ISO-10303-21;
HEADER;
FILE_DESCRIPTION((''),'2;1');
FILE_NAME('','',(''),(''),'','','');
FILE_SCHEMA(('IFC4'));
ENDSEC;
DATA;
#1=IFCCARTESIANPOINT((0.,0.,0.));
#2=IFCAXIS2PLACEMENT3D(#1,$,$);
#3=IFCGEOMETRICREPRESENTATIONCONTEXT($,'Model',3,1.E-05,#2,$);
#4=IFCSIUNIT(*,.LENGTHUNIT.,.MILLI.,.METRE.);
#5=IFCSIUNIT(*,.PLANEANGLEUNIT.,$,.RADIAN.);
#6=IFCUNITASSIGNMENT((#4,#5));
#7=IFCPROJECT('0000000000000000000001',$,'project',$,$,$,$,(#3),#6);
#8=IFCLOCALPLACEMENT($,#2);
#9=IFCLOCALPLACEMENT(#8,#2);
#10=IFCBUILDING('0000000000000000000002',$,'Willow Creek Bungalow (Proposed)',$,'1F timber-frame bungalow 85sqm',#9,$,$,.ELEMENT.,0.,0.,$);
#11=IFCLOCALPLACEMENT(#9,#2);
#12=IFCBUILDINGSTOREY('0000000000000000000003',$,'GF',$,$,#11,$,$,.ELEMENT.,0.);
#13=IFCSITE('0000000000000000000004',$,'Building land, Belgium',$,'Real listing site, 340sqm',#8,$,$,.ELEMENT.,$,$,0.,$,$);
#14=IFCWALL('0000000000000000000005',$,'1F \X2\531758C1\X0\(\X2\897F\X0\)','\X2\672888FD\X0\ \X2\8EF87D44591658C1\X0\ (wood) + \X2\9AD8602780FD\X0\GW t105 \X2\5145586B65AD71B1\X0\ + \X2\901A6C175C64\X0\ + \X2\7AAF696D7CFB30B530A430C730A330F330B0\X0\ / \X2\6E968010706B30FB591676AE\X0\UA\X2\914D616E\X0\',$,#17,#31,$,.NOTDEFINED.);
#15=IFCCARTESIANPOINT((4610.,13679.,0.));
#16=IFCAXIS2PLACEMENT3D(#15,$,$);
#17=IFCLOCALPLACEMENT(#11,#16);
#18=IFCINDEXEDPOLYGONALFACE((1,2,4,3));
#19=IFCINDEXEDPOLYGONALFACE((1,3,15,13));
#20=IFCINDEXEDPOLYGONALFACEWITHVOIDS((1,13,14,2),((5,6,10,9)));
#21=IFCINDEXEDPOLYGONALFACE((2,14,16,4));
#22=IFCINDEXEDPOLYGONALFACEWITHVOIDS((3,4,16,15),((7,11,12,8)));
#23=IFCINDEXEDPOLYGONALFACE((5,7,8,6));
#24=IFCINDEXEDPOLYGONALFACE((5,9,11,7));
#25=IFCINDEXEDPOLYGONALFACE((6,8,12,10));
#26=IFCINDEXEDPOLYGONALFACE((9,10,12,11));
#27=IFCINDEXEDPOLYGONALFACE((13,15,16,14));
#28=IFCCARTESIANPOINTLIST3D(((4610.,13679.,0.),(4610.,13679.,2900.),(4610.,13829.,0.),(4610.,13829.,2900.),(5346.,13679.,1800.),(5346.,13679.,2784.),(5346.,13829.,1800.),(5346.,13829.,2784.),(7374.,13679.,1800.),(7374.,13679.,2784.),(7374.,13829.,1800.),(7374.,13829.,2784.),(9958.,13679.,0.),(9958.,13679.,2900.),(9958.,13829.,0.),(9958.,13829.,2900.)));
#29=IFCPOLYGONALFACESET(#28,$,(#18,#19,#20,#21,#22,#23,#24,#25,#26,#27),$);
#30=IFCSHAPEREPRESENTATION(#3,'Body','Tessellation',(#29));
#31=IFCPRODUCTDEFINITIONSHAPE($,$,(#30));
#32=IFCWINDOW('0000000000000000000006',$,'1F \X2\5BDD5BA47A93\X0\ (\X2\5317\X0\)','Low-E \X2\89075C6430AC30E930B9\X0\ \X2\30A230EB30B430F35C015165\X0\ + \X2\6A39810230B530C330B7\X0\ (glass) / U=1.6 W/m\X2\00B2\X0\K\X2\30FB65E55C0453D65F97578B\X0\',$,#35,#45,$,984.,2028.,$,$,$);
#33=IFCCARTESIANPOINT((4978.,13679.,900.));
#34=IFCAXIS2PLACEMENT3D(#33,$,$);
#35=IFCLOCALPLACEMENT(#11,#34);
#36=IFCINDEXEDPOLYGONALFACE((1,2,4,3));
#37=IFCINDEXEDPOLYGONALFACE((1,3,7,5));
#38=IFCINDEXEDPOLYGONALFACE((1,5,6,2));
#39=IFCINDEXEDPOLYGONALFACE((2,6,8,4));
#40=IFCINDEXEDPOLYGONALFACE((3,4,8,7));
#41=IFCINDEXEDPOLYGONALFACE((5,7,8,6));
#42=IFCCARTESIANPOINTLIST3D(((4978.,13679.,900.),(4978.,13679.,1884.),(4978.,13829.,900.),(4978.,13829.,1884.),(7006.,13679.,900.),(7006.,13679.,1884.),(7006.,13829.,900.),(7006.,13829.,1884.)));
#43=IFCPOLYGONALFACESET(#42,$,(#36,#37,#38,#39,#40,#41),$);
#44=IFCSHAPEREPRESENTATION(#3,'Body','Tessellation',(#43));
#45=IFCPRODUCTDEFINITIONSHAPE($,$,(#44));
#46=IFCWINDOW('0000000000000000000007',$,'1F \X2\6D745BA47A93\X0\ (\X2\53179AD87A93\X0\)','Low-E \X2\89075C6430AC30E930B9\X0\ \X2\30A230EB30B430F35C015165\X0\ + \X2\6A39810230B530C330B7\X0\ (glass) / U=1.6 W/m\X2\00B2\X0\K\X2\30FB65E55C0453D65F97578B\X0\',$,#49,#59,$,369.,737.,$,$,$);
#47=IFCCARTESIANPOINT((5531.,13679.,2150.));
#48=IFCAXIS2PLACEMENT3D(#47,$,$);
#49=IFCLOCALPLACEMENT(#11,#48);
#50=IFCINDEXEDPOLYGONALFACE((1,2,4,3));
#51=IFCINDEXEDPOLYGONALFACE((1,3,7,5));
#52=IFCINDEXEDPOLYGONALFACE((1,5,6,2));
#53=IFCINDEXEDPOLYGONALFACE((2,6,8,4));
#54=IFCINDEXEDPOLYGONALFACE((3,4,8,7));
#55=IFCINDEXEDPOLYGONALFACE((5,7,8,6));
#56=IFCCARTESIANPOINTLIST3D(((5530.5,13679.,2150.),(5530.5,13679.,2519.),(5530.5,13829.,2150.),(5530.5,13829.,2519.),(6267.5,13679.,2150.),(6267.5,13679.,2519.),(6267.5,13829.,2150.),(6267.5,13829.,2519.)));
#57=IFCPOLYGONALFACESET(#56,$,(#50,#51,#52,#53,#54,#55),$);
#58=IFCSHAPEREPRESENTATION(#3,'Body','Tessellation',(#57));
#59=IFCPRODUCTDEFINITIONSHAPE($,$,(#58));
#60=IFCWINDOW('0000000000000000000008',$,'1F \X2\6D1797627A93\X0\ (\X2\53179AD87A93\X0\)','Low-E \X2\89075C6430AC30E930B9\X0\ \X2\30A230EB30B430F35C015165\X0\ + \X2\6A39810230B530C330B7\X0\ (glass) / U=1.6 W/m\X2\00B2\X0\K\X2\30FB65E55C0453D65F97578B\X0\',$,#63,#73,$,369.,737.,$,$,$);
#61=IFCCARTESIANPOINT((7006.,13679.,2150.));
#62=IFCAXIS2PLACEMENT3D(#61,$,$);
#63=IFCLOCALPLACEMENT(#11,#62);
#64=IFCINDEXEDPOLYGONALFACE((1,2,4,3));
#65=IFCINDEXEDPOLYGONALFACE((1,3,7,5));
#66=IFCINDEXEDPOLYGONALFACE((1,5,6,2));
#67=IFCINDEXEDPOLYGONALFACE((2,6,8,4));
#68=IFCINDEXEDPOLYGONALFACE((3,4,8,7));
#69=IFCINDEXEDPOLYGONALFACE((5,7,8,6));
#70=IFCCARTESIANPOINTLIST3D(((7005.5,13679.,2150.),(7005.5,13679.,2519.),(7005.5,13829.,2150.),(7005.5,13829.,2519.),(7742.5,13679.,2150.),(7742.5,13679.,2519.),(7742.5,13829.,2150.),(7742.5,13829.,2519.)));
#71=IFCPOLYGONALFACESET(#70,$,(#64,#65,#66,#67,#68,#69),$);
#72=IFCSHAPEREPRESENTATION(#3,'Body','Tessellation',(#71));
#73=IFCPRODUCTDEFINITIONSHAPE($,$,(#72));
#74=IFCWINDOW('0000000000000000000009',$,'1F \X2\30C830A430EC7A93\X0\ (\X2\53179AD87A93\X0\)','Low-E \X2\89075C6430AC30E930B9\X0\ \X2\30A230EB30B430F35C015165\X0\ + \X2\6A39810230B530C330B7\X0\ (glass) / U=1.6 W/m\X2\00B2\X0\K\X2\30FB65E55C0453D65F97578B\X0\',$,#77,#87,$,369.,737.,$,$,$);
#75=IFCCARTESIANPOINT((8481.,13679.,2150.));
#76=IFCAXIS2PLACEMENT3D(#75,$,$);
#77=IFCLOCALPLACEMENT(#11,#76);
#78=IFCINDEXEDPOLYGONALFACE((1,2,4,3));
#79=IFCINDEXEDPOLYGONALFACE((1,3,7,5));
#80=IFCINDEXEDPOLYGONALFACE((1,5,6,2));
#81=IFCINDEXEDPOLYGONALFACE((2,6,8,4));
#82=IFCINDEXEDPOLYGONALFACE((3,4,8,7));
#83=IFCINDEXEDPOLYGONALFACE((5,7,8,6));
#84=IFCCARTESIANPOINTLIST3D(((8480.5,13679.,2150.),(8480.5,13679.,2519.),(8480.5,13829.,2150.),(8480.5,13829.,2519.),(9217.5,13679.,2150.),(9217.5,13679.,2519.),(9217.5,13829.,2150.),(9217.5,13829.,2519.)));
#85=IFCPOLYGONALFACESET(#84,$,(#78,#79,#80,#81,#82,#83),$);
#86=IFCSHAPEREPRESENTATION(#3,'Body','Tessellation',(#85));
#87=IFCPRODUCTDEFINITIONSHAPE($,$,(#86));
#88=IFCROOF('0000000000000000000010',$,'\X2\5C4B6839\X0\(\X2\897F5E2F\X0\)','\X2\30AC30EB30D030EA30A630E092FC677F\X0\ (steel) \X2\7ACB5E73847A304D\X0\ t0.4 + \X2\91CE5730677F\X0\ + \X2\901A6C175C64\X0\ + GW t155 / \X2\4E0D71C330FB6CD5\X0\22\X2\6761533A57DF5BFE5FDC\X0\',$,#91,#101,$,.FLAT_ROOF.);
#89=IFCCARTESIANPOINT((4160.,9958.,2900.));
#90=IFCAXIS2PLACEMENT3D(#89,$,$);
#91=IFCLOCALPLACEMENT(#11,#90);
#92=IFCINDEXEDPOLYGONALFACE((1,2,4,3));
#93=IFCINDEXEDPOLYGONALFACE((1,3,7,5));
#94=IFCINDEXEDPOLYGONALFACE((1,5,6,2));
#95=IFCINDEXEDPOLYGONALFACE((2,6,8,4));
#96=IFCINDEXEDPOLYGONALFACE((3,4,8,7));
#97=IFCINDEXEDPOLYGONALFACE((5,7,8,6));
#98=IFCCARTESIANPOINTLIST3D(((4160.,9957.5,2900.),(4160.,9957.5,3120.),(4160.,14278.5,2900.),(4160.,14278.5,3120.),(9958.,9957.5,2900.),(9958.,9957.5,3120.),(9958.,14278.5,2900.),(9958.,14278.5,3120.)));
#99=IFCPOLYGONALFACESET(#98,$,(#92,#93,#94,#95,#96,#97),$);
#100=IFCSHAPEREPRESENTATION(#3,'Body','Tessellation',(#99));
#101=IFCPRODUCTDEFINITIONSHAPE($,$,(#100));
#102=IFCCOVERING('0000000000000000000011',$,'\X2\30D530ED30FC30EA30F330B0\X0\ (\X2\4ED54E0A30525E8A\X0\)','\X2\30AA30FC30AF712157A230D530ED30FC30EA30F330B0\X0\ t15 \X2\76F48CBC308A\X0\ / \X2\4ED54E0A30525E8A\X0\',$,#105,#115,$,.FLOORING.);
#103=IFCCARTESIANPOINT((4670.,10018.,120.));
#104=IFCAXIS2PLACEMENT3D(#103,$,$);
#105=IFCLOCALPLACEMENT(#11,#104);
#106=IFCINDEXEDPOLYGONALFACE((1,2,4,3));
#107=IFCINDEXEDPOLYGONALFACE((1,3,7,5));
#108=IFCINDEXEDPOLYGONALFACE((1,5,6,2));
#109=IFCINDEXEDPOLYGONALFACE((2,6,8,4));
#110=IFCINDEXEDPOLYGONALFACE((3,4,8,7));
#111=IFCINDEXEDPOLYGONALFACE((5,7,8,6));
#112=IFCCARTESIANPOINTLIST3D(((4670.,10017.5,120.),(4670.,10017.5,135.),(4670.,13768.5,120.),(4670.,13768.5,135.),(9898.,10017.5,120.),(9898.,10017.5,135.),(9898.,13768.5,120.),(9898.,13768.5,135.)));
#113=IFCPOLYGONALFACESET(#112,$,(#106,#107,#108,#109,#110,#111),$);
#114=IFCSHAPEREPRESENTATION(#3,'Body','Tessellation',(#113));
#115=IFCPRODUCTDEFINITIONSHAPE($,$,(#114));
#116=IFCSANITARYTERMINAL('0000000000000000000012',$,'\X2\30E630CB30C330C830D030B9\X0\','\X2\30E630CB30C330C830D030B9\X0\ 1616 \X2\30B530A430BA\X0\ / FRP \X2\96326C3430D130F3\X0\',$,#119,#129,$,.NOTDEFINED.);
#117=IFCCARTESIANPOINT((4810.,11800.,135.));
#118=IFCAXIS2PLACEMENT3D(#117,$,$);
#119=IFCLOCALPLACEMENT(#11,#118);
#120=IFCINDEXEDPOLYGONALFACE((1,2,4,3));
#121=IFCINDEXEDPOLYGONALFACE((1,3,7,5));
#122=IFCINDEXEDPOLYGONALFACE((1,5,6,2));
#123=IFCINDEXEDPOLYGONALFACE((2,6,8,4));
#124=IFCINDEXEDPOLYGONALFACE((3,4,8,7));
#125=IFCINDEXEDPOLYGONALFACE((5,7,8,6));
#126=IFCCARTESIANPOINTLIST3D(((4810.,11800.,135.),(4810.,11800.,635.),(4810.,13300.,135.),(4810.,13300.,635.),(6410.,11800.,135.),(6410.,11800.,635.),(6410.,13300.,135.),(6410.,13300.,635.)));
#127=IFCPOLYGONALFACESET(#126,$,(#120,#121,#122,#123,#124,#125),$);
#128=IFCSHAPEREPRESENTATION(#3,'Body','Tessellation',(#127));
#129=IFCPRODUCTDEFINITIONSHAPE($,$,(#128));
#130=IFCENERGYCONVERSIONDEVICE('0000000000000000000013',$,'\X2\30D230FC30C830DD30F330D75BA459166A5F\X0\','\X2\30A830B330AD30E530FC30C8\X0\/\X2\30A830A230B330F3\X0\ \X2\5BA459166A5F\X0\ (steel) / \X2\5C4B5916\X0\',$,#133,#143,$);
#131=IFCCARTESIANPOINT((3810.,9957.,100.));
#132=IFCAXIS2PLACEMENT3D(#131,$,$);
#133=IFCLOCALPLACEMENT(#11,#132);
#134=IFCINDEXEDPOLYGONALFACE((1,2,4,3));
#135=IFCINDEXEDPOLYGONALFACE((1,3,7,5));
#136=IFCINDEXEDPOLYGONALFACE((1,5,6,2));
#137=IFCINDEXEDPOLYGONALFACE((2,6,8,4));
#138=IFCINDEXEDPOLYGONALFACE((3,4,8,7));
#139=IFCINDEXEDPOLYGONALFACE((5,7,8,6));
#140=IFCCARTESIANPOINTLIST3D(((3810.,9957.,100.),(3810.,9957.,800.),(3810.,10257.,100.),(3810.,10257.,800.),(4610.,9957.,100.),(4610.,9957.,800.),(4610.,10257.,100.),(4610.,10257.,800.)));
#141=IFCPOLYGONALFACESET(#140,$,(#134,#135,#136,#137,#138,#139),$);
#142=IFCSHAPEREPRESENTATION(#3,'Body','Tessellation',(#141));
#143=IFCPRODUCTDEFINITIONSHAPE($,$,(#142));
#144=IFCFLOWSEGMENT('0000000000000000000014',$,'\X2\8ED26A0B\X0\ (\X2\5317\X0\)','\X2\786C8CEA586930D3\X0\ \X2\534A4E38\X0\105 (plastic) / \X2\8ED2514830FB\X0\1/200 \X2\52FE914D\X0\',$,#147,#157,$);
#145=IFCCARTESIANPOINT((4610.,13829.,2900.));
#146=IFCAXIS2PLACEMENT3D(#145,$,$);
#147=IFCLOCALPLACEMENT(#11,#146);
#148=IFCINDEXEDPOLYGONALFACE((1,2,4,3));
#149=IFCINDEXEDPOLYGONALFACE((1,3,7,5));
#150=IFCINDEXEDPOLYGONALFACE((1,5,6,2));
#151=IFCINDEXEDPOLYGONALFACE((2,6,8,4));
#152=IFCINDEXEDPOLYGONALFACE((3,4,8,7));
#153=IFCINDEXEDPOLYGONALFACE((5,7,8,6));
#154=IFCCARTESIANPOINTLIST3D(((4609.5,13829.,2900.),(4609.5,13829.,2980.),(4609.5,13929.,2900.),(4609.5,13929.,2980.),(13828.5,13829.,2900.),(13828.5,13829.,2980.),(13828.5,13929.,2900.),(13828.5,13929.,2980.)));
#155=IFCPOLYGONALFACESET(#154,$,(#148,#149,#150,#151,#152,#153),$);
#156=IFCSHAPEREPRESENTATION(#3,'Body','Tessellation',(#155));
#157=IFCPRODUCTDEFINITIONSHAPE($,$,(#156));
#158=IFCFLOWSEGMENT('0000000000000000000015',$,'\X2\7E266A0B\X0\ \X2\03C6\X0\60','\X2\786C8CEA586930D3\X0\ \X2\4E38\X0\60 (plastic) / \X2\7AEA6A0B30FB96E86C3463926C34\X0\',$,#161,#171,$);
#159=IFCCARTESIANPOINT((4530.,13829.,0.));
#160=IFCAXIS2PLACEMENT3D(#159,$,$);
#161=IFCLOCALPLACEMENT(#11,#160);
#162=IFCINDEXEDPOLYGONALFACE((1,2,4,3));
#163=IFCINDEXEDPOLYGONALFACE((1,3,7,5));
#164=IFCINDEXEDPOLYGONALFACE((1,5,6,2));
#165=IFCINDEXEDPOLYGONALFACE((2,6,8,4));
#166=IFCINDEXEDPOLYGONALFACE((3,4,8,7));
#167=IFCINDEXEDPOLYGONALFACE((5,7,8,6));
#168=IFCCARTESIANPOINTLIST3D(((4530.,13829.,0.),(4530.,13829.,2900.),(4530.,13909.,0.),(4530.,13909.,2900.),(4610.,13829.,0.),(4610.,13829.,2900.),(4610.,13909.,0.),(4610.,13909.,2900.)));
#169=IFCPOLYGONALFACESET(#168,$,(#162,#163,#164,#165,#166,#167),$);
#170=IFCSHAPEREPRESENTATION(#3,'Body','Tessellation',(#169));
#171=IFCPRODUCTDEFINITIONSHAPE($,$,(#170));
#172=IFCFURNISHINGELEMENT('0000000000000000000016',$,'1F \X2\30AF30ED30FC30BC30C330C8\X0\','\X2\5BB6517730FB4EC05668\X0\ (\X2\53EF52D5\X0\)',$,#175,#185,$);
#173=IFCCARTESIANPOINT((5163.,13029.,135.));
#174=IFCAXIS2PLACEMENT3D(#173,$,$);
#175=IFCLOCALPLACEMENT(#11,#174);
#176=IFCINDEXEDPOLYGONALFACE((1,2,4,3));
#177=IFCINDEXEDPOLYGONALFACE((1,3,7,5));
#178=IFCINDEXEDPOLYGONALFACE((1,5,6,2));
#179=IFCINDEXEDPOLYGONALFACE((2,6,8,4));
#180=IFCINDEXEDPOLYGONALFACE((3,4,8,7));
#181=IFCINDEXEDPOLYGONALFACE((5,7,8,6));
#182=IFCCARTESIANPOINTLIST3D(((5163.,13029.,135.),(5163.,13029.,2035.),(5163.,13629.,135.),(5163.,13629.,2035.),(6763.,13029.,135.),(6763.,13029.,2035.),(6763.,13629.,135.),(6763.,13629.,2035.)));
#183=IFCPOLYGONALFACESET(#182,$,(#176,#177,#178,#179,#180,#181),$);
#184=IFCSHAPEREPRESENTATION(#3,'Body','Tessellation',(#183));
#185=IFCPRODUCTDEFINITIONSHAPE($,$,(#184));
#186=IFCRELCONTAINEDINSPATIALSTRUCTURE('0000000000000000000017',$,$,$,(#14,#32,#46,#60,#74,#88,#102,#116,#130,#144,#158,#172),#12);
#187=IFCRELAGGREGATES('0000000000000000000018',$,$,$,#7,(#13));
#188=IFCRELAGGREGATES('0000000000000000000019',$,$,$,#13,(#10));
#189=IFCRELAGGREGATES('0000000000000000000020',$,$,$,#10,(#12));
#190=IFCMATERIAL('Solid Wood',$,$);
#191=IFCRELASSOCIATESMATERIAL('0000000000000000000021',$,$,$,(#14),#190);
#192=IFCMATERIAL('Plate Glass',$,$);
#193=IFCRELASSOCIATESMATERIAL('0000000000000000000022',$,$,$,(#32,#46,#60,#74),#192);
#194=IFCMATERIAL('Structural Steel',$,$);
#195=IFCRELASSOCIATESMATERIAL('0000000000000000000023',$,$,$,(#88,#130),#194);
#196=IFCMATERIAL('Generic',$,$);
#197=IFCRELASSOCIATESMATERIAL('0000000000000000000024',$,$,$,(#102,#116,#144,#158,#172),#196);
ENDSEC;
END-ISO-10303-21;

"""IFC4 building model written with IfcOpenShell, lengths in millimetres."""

from ifc_helpers import new_model, si_unit, frame, frame_2d, origin, place, context, project, spatial, rectangle, extrude, material, element, fill, save


model = new_model("IFC4")

# Units and contexts
model_context = context("Model", 3, precision=1e-05, world=origin())
ifc_project = project(units=[si_unit("LENGTHUNIT", "METRE", prefix="MILLI"), si_unit("PLANEANGLEUNIT", "RADIAN")], contexts=[model_context])

# Site, building, storey
site_placement = place(None, origin())
site = spatial("IfcSite", under=ifc_project, at=site_placement, Name="Building land, Belgium", ObjectType="Real listing site, 340sqm", CompositionType="ELEMENT", RefElevation=0.0)
building_placement = place(site_placement, origin())
building = spatial("IfcBuilding", under=site, at=building_placement, Name="Willow Creek Bungalow (Proposed)", ObjectType="1F timber-frame bungalow 85sqm", CompositionType="ELEMENT", ElevationOfRefHeight=0.0, ElevationOfTerrain=0.0)
storey_placement = place(building_placement, origin())
storey = spatial("IfcBuildingStorey", under=building, at=storey_placement, Name="GF", CompositionType="ELEMENT", Elevation=0.0)

# Shared definitions
ifc_material_1 = material(Name="Solid Wood")

# Wall, openings, windows
wall_1_placement = place(storey_placement, frame((4610.0, 13679.0, 0.0)))
wall_1 = element("IfcWall", 1, at=wall_1_placement, inside=storey, material=ifc_material_1, Name="1F 北壁(西)", Description="木製 軸組外壁 (wood) + 高性能GW t105 充填断熱 + 通気層 + 窯業系サイディング / 準耐火・外皮UA配慮", PredefinedType="NOTDEFINED", context=model_context, shape_type="SweptSolid", body=[
    extrude(rectangle(XDim=5348.0, YDim=150.0, at=frame_2d((2674.0, 75.0))), frame((4610.0, 13679.0, 0.0)), (0.0, 0.0, 1.0), 2900.0),
])
opening_1_placement = place(storey_placement, frame((4978.0, 13679.0, 900.0)))
opening_1 = element("IfcOpeningElement", 2, at=opening_1_placement, cuts=wall_1, PredefinedType="NOTDEFINED", context=model_context, shape_type="SweptSolid", body=[
    extrude(rectangle(XDim=2028.0, YDim=150.0, at=frame_2d((1014.0, 75.0))), frame((4978.0, 13679.0, 900.0)), (0.0, 0.0, 1.0), 984.0),
])
opening_2_placement = place(storey_placement, frame((5531.0, 13679.0, 2150.0)))
opening_2 = element("IfcOpeningElement", 3, at=opening_2_placement, cuts=wall_1, PredefinedType="NOTDEFINED", context=model_context, shape_type="SweptSolid", body=[
    extrude(rectangle(XDim=737.0, YDim=150.0, at=frame_2d((368.0, 75.0))), frame((5531.0, 13679.0, 2150.0)), (0.0, 0.0, 1.0), 369.0),
])
opening_3_placement = place(storey_placement, frame((7006.0, 13679.0, 2150.0)))
opening_3 = element("IfcOpeningElement", 4, at=opening_3_placement, cuts=wall_1, PredefinedType="NOTDEFINED", context=model_context, shape_type="SweptSolid", body=[
    extrude(rectangle(XDim=737.0, YDim=150.0, at=frame_2d((368.0, 75.0))), frame((7006.0, 13679.0, 2150.0)), (0.0, 0.0, 1.0), 369.0),
])
opening_4_placement = place(storey_placement, frame((8481.0, 13679.0, 2150.0)))
opening_4 = element("IfcOpeningElement", 5, at=opening_4_placement, cuts=wall_1, PredefinedType="NOTDEFINED", context=model_context, shape_type="SweptSolid", body=[
    extrude(rectangle(XDim=737.0, YDim=150.0, at=frame_2d((368.0, 75.0))), frame((8481.0, 13679.0, 2150.0)), (0.0, 0.0, 1.0), 369.0),
])
ifc_material_2 = material(Name="Plate Glass")
window_1_placement = place(storey_placement, frame((4978.0, 13679.0, 900.0)))
window_1 = element("IfcWindow", 6, at=window_1_placement, inside=storey, material=ifc_material_2, Name="1F 寝室窓 (北)", Description="Low-E 複層ガラス アルゴン封入 + 樹脂サッシ (glass) / U=1.6 W/m²K・日射取得型", OverallHeight=984.0, OverallWidth=2028.0, context=model_context, shape_type="SweptSolid", body=[
    extrude(rectangle(XDim=2028.0, YDim=150.0, at=frame_2d((1014.0, 75.0))), frame((4978.0, 13679.0, 900.0)), (0.0, 0.0, 1.0), 984.0),
])
fill(opening_1, window_1)
window_2_placement = place(storey_placement, frame((5531.0, 13679.0, 2150.0)))
window_2 = element("IfcWindow", 7, at=window_2_placement, inside=storey, material=ifc_material_2, Name="1F 浴室窓 (北高窓)", Description="Low-E 複層ガラス アルゴン封入 + 樹脂サッシ (glass) / U=1.6 W/m²K・日射取得型", OverallHeight=369.0, OverallWidth=737.0, context=model_context, shape_type="SweptSolid", body=[
    extrude(rectangle(XDim=737.0, YDim=150.0, at=frame_2d((368.0, 75.0))), frame((5531.0, 13679.0, 2150.0)), (0.0, 0.0, 1.0), 369.0),
])
fill(opening_2, window_2)
window_3_placement = place(storey_placement, frame((7006.0, 13679.0, 2150.0)))
window_3 = element("IfcWindow", 8, at=window_3_placement, inside=storey, material=ifc_material_2, Name="1F 洗面窓 (北高窓)", Description="Low-E 複層ガラス アルゴン封入 + 樹脂サッシ (glass) / U=1.6 W/m²K・日射取得型", OverallHeight=369.0, OverallWidth=737.0, context=model_context, shape_type="SweptSolid", body=[
    extrude(rectangle(XDim=737.0, YDim=150.0, at=frame_2d((368.0, 75.0))), frame((7006.0, 13679.0, 2150.0)), (0.0, 0.0, 1.0), 369.0),
])
fill(opening_3, window_3)
window_4_placement = place(storey_placement, frame((8481.0, 13679.0, 2150.0)))
window_4 = element("IfcWindow", 9, at=window_4_placement, inside=storey, material=ifc_material_2, Name="1F トイレ窓 (北高窓)", Description="Low-E 複層ガラス アルゴン封入 + 樹脂サッシ (glass) / U=1.6 W/m²K・日射取得型", OverallHeight=369.0, OverallWidth=737.0, context=model_context, shape_type="SweptSolid", body=[
    extrude(rectangle(XDim=737.0, YDim=150.0, at=frame_2d((368.0, 75.0))), frame((8481.0, 13679.0, 2150.0)), (0.0, 0.0, 1.0), 369.0),
])
fill(opening_4, window_4)

# Roof
ifc_material_3 = material(Name="Structural Steel")
roof_placement = place(storey_placement, frame((4160.0, 9958.0, 2900.0)))
element("IfcRoof", 10, at=roof_placement, inside=storey, material=ifc_material_3, Name="屋根(西帯)", Description="ガルバリウム鋼板 (steel) 立平葺き t0.4 + 野地板 + 通気層 + GW t155 / 不燃・法22条区域対応", PredefinedType="FLAT_ROOF", context=model_context, shape_type="SweptSolid", body=[
    extrude(rectangle(XDim=5798.0, YDim=4321.0, at=frame_2d((2899.0, 2160.0))), frame((4160.0, 9958.0, 2900.0)), (0.0, 0.0, 1.0), 220.0),
])

# Covering
ifc_material_4 = material(Name="Generic")
covering_placement = place(storey_placement, frame((4670.0, 10018.0, 120.0)))
element("IfcCovering", 11, at=covering_placement, inside=storey, material=ifc_material_4, Name="フローリング (仕上げ床)", Description="オーク無垢フローリング t15 直貼り / 仕上げ床", PredefinedType="FLOORING", context=model_context, shape_type="SweptSolid", body=[
    extrude(rectangle(XDim=5228.0, YDim=3751.0, at=frame_2d((2614.0, 1875.0))), frame((4670.0, 10018.0, 120.0)), (0.0, 0.0, 1.0), 15.0),
])

# Sanitary terminal
sanitary_terminal_placement = place(storey_placement, frame((4810.0, 11800.0, 135.0)))
element("IfcSanitaryTerminal", 12, at=sanitary_terminal_placement, inside=storey, material=ifc_material_4, Name="ユニットバス", Description="ユニットバス 1616 サイズ / FRP 防水パン", PredefinedType="NOTDEFINED", context=model_context, shape_type="SweptSolid", body=[
    extrude(rectangle(XDim=1600.0, YDim=1500.0, at=frame_2d((800.0, 750.0))), frame((4810.0, 11800.0, 135.0)), (0.0, 0.0, 1.0), 500.0),
])

# Energy conversion device
energy_conversion_device_placement = place(storey_placement, frame((3810.0, 9957.0, 100.0)))
element("IfcEnergyConversionDevice", 13, at=energy_conversion_device_placement, inside=storey, material=ifc_material_3, Name="ヒートポンプ室外機", Description="エコキュート/エアコン 室外機 (steel) / 屋外", context=model_context, shape_type="SweptSolid", body=[
    extrude(rectangle(XDim=800.0, YDim=300.0, at=frame_2d((400.0, 150.0))), frame((3810.0, 9957.0, 100.0)), (0.0, 0.0, 1.0), 700.0),
])

# Flow segments
flow_segment_1_placement = place(storey_placement, frame((4610.0, 13829.0, 2900.0)))
element("IfcFlowSegment", 14, at=flow_segment_1_placement, inside=storey, material=ifc_material_4, Name="軒樋 (北)", Description="硬質塩ビ 半丸105 (plastic) / 軒先・1/200 勾配", context=model_context, shape_type="SweptSolid", body=[
    extrude(rectangle(XDim=9219.0, YDim=100.0, at=frame_2d((4609.0, 50.0))), frame((4610.0, 13829.0, 2900.0)), (0.0, 0.0, 1.0), 80.0),
])
flow_segment_2_placement = place(storey_placement, frame((4530.0, 13829.0, 0.0)))
element("IfcFlowSegment", 15, at=flow_segment_2_placement, inside=storey, material=ifc_material_4, Name="縦樋 φ60", Description="硬質塩ビ 丸60 (plastic) / 竪樋・雨水排水", context=model_context, shape_type="SweptSolid", body=[
    extrude(rectangle(XDim=80.0, YDim=80.0, at=frame_2d((40.0, 40.0))), frame((4530.0, 13829.0, 0.0)), (0.0, 0.0, 1.0), 2900.0),
])

# Furnishing element
furnishing_1_placement = place(storey_placement, frame((5163.0, 13029.0, 135.0)))
element("IfcFurnishingElement", 16, at=furnishing_1_placement, inside=storey, material=ifc_material_4, Name="1F クローゼット", Description="家具・什器 (可動)", context=model_context, shape_type="SweptSolid", body=[
    extrude(rectangle(XDim=1600.0, YDim=600.0, at=frame_2d((800.0, 300.0))), frame((5163.0, 13029.0, 135.0)), (0.0, 0.0, 1.0), 1900.0),
])

save(model, "model.ifc")
